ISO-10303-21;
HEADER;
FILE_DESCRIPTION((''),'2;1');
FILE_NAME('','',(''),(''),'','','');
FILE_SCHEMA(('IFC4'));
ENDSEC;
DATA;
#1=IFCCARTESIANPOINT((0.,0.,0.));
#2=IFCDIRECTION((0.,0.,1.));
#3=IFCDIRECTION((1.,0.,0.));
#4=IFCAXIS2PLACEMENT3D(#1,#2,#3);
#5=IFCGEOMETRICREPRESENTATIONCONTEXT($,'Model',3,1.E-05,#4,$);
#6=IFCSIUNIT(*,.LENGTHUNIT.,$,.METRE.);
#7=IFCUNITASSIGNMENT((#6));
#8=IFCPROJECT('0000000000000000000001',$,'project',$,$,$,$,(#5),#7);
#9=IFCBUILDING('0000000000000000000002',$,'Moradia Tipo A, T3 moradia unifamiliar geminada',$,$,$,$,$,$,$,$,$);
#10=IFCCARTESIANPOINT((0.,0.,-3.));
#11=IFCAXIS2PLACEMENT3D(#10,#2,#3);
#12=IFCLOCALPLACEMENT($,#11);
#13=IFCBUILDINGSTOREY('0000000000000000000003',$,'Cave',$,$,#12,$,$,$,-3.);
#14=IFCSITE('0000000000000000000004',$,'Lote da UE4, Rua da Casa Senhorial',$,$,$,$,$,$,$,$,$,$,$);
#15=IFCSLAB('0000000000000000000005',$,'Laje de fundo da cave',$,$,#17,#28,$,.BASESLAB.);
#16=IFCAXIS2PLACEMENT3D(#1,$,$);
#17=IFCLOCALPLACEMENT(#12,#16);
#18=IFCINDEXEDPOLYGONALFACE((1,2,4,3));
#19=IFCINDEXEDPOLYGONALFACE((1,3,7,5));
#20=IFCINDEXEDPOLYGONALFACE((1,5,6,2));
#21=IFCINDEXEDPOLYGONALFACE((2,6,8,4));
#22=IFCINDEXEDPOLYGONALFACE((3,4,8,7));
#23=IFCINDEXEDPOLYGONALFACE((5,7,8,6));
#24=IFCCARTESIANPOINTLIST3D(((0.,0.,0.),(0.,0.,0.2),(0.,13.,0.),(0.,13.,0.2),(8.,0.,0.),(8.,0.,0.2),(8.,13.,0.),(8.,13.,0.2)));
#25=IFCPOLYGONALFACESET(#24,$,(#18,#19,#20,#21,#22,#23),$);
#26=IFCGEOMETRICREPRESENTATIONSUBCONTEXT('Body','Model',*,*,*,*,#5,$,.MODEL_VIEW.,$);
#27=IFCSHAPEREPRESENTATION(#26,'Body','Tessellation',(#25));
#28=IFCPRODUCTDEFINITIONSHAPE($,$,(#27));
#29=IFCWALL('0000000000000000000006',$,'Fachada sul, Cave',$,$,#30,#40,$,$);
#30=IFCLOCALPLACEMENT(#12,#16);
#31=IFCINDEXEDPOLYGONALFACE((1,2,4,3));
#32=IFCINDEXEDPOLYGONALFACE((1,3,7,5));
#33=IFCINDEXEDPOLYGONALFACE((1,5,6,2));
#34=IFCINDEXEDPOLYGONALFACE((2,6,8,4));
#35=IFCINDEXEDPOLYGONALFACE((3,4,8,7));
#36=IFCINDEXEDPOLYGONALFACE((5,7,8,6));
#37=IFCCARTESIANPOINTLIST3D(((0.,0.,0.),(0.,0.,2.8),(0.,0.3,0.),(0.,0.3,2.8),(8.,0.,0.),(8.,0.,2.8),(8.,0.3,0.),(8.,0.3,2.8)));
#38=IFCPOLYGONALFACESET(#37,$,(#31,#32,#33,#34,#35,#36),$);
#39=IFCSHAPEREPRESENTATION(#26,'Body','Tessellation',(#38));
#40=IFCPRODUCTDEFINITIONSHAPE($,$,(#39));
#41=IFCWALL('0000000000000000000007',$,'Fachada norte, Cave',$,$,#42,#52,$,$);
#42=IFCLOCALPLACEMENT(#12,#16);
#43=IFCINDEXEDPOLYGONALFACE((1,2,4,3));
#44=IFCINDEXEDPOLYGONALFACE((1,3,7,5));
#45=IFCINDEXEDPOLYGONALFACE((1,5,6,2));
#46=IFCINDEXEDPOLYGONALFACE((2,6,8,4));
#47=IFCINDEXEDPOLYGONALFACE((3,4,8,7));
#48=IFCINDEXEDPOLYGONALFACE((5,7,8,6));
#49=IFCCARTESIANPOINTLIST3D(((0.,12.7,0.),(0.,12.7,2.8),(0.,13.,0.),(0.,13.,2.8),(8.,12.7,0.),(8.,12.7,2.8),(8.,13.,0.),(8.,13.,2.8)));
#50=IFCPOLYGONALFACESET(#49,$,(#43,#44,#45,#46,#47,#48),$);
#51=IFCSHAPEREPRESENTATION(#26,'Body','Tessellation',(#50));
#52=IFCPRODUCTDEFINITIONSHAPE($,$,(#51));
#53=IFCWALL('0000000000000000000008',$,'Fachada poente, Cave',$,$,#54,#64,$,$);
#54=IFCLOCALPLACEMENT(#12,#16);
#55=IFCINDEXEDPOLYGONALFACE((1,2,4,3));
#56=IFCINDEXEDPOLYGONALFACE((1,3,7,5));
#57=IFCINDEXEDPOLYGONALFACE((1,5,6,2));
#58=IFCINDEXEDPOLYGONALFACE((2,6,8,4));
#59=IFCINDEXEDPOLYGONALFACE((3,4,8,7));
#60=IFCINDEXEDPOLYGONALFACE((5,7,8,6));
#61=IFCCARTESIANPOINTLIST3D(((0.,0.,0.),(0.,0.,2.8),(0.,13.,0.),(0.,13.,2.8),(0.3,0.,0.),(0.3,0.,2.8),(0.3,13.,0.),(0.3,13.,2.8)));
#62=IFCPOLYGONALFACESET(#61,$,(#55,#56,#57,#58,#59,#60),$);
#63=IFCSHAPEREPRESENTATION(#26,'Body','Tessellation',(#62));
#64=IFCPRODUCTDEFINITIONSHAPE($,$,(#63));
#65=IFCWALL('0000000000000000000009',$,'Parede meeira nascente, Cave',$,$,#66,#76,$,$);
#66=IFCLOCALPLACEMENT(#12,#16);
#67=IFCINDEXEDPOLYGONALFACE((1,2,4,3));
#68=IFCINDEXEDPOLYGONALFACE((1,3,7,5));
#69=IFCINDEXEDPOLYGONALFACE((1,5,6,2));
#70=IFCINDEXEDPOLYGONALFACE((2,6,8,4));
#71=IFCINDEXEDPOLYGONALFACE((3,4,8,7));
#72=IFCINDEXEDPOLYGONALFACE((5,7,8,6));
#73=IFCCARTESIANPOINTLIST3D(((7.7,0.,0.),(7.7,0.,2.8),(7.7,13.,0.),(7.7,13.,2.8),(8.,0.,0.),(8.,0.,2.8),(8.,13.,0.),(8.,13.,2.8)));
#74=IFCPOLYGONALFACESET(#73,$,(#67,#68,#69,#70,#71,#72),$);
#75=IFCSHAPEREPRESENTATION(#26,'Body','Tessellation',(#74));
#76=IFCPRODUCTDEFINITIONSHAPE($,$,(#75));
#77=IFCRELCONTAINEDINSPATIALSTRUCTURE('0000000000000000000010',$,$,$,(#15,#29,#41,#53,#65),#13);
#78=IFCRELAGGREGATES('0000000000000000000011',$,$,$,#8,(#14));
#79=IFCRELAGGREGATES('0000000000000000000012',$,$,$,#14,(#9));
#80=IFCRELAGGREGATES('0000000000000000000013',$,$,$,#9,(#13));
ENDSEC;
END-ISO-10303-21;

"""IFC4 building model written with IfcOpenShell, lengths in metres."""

from ifc_helpers import new_model, si_unit, frame, origin_with_axes, place, context, subcontext, project, spatial, indexed_curve, outline, extrude, element, save


model = new_model("IFC4")

# Units and contexts
model_context = context("Model", 3, precision=1e-05, world=origin_with_axes())
body_context = subcontext(model_context, "Body", "Model", "MODEL_VIEW")
ifc_project = project(units=[si_unit("LENGTHUNIT", "METRE")], contexts=[model_context])

# Site, building, storey
site = spatial("IfcSite", under=ifc_project, Name="Lote da UE4, Rua da Casa Senhorial")
building = spatial("IfcBuilding", under=site, Name="Moradia Tipo A, T3 moradia unifamiliar geminada")
storey_placement = place(None, frame((0.0, 0.0, -3.0), z_axis=(0.0, 0.0, 1.0), x_axis=(1.0, 0.0, 0.0)))
storey = spatial("IfcBuildingStorey", under=building, at=storey_placement, Name="Cave", Elevation=-3.0)

# Slab
slab_placement = place(storey_placement, origin_with_axes())
element("IfcSlab", 1, at=slab_placement, inside=storey, Name="Laje de fundo da cave", PredefinedType="BASESLAB", context=body_context, shape_type="SweptSolid", body=[
    extrude(outline(indexed_curve([(0.0, 0.0), (8.0, 0.0), (8.0, 13.0), (0.0, 13.0), (0.0, 0.0)])), None, (0.0, 0.0, 1.0), 0.2),
])

# Walls
for number, where, z_axis, x_axis, name in (
    (2, (0.0, 0.0, 0.0), (0.0, 0.0, 1.0), (1.0, 0.0, 0.0), "Fachada sul, Cave"),
    (3, (0.0, 12.7, 0.0), (0.0, 0.0, 1.0), (1.0, 0.0, 0.0), "Fachada norte, Cave"),
):
    element("IfcWall", number, at=place(storey_placement, frame(where, z_axis=z_axis, x_axis=x_axis)), inside=storey, Name=name, context=body_context, shape_type="SweptSolid", body=[
        extrude(outline(indexed_curve([(0.0, 0.0), (0.0, 0.3), (8.0, 0.3), (8.0, 0.0), (0.0, 0.0)], self_intersect=False)), origin_with_axes(), (0.0, 0.0, 1.0), 2.8),
    ])
for number, where, z_axis, x_axis, name in (
    (4, (0.3, 0.0, 0.0), (0.0, 0.0, 1.0), (0.0, 1.0, 0.0), "Fachada poente, Cave"),
    (5, (8.0, 0.0, 0.0), (0.0, 0.0, 1.0), (0.0, 1.0, 0.0), "Parede meeira nascente, Cave"),
):
    element("IfcWall", number, at=place(storey_placement, frame(where, z_axis=z_axis, x_axis=x_axis)), inside=storey, Name=name, context=body_context, shape_type="SweptSolid", body=[
        extrude(outline(indexed_curve([(0.0, 0.0), (0.0, 0.3), (13.0, 0.3), (13.0, 0.0), (0.0, 0.0)], self_intersect=False)), origin_with_axes(), (0.0, 0.0, 1.0), 2.8),
    ])

save(model, "model.ifc")
